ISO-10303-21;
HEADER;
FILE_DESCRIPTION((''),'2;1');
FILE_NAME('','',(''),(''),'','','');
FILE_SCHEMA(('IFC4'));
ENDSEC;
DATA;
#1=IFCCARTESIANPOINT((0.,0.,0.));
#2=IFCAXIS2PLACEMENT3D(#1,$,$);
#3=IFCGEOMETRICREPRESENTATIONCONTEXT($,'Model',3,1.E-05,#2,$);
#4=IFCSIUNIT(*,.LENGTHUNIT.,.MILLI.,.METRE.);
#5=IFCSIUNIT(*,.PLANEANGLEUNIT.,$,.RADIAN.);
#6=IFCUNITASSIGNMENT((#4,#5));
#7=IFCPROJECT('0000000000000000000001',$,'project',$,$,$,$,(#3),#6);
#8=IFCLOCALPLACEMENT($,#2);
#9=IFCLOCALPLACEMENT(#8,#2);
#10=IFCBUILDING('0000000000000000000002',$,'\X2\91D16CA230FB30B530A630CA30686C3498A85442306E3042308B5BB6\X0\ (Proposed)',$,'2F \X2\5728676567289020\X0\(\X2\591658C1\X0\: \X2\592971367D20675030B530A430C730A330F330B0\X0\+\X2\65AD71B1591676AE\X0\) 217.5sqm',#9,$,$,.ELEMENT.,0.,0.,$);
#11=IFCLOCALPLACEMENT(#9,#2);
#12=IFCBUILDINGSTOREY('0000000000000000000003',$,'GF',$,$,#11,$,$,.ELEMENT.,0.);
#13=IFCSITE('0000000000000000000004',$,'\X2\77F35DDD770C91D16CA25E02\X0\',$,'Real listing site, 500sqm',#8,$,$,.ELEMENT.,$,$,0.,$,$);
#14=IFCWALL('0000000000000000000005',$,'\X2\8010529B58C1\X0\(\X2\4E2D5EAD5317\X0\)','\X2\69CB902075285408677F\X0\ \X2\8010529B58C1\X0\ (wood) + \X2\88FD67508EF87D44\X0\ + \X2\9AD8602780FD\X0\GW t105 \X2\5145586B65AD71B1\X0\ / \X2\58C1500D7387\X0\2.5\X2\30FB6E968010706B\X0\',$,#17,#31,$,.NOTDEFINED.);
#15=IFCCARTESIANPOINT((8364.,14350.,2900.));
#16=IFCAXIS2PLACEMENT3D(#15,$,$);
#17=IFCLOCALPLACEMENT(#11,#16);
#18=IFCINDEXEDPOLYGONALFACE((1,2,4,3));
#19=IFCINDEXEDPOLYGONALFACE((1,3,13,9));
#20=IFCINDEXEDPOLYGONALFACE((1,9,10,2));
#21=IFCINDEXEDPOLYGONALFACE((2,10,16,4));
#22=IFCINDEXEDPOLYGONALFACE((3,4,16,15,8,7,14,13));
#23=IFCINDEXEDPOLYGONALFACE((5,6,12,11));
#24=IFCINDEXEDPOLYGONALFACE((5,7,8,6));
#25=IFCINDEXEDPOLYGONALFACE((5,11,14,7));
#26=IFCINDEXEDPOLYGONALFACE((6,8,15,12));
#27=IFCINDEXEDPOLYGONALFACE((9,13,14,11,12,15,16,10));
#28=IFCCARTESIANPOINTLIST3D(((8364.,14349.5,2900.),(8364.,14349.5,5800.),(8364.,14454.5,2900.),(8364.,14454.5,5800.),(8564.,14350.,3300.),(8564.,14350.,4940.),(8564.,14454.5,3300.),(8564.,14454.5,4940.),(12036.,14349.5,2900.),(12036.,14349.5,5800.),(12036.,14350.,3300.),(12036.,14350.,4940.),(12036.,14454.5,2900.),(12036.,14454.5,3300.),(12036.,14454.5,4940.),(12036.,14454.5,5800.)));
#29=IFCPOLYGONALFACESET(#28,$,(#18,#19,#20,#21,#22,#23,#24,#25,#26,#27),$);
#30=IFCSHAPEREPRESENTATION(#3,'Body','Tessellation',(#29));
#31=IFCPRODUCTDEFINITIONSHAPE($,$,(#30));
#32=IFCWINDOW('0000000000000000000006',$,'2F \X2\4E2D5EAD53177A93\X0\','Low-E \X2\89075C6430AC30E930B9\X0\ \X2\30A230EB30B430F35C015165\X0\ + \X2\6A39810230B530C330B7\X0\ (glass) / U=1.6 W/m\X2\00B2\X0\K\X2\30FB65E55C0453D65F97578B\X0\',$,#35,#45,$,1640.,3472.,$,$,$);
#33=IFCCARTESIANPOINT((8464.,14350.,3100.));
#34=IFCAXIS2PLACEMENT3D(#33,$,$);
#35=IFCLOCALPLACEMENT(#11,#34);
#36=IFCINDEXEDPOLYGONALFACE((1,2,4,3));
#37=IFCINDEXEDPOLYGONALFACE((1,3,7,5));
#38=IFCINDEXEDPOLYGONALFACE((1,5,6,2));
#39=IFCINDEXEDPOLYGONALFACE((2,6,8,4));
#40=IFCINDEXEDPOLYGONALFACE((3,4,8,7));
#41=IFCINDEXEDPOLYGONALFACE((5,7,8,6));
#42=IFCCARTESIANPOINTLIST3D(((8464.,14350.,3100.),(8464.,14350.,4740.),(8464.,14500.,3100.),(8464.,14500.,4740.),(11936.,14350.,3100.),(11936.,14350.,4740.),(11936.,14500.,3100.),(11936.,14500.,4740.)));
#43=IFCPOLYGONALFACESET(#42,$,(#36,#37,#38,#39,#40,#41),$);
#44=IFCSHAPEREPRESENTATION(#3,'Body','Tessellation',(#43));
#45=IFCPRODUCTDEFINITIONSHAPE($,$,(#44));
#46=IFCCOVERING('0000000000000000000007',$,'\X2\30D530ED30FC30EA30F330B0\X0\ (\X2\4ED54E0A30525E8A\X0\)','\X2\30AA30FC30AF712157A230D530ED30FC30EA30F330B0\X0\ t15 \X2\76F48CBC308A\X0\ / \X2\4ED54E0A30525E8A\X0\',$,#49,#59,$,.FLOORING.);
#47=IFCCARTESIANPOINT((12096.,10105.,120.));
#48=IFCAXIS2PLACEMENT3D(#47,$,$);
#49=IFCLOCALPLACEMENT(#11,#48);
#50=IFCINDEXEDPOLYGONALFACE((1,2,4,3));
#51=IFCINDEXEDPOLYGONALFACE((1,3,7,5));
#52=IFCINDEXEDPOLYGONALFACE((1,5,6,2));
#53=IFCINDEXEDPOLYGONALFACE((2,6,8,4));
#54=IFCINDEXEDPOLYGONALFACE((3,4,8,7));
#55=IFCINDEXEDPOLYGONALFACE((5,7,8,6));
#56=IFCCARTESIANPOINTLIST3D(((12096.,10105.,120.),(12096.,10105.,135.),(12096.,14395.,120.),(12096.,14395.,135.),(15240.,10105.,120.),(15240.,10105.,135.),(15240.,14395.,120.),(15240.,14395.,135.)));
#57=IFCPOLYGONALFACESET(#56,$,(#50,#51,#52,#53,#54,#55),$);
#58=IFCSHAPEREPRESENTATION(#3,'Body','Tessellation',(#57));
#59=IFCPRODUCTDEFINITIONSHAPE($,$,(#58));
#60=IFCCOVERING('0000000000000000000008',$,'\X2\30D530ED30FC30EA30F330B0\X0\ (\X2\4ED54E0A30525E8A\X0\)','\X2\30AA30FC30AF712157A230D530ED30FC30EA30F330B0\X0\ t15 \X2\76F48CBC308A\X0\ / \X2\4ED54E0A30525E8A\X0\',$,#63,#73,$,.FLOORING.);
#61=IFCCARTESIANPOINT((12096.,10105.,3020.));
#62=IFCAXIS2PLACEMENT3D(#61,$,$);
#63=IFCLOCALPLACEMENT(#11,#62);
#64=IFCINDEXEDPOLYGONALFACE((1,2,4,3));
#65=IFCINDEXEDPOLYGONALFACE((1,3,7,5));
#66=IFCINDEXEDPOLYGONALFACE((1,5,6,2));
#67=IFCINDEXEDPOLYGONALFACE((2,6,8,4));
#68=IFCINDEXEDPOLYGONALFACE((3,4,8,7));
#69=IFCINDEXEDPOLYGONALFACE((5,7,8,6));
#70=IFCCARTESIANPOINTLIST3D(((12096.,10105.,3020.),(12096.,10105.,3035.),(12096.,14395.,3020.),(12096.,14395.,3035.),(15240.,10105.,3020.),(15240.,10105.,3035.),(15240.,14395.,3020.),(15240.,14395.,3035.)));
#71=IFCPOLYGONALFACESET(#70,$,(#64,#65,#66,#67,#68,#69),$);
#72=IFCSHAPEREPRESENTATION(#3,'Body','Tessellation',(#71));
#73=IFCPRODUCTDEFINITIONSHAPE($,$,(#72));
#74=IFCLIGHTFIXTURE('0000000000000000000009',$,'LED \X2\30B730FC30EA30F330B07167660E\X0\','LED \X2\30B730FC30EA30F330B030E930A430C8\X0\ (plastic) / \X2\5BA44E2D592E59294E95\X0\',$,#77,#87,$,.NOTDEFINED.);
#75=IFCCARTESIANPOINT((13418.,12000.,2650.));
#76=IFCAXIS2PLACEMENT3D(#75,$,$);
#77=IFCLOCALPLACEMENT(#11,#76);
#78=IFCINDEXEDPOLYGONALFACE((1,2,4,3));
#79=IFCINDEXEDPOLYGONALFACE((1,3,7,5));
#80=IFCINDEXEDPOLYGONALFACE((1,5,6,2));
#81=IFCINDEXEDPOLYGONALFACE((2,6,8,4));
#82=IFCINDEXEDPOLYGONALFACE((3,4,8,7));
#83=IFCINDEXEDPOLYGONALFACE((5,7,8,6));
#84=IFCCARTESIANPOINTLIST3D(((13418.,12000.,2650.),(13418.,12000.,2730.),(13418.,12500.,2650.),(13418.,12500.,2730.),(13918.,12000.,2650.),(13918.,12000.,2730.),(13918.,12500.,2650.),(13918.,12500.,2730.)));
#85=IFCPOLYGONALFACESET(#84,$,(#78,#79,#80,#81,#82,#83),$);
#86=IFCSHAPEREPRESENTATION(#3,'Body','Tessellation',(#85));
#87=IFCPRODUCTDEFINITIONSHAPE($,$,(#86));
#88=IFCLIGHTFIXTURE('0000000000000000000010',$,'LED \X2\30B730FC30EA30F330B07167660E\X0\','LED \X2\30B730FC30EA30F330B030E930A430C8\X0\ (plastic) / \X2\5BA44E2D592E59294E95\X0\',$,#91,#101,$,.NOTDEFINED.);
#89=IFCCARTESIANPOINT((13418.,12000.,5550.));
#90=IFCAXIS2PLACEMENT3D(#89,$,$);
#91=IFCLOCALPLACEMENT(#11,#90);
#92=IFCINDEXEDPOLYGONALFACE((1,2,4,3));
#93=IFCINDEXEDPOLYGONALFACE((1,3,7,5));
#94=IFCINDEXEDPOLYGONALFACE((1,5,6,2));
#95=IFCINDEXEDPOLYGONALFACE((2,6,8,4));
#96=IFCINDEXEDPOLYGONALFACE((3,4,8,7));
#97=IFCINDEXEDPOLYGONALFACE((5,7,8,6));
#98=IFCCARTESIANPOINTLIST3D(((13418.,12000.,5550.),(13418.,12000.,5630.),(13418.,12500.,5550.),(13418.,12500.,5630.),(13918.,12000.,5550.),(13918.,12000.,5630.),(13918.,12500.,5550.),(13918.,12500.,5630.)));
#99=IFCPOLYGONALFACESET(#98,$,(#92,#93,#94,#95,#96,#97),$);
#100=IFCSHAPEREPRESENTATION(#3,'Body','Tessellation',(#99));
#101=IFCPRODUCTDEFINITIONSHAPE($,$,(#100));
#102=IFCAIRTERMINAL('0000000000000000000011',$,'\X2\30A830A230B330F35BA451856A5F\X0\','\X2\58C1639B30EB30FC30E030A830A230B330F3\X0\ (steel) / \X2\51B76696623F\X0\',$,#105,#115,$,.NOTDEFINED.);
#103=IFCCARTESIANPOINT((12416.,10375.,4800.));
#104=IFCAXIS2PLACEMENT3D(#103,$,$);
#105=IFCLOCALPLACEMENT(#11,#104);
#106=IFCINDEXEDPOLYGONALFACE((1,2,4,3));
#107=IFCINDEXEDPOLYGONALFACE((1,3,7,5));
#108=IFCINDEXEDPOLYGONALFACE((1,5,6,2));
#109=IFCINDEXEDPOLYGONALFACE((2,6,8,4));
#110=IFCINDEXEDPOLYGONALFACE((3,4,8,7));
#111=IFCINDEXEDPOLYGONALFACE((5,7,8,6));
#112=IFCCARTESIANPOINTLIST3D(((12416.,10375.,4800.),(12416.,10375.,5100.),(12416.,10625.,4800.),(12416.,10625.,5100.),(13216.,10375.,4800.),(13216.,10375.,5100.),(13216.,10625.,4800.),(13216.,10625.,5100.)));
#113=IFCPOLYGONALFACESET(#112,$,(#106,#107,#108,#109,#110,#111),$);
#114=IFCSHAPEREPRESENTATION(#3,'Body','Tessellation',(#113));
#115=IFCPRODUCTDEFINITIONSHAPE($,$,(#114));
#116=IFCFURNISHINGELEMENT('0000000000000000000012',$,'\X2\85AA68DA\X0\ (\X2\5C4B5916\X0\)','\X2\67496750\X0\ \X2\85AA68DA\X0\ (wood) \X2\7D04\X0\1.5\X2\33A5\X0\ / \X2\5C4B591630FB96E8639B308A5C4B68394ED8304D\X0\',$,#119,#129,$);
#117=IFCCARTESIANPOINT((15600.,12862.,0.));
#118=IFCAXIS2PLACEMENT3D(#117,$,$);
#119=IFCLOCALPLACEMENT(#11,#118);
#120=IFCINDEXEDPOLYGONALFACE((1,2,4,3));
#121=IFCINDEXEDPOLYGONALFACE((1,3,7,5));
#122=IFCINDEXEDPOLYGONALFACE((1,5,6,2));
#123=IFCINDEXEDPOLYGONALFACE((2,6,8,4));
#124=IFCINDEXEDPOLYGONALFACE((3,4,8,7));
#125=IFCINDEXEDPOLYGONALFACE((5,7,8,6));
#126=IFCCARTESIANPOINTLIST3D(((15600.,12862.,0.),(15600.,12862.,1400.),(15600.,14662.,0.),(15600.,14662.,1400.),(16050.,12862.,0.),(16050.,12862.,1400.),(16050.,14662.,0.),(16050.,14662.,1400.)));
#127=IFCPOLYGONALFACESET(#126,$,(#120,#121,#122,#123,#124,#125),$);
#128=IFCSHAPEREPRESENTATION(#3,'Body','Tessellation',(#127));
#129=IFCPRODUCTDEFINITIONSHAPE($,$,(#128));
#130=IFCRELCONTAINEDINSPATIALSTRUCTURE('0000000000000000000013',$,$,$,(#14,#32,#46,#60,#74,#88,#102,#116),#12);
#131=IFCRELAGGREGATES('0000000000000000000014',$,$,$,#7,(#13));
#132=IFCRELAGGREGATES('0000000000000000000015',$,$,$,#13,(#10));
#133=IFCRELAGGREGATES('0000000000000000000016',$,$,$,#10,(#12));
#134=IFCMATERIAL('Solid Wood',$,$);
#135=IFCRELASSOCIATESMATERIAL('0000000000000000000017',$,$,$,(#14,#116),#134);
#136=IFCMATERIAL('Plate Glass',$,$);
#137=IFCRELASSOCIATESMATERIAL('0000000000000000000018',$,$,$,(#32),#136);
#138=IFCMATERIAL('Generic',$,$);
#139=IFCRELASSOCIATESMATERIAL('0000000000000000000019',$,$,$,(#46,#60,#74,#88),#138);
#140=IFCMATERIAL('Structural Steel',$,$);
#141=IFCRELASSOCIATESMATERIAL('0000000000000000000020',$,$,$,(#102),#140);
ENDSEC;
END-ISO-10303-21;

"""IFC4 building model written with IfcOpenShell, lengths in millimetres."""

from ifc_helpers import new_model, si_unit, frame, frame_2d, origin, place, context, project, spatial, rectangle, extrude, material, element, fill, save


model = new_model("IFC4")

# Units and contexts
model_context = context("Model", 3, precision=1e-05, world=origin())
ifc_project = project(units=[si_unit("LENGTHUNIT", "METRE", prefix="MILLI"), si_unit("PLANEANGLEUNIT", "RADIAN")], contexts=[model_context])

# Site, building, storey
site_placement = place(None, origin())
site = spatial("IfcSite", under=ifc_project, at=site_placement, Name="石川県金沢市", ObjectType="Real listing site, 500sqm", CompositionType="ELEMENT", RefElevation=0.0)
building_placement = place(site_placement, origin())
building = spatial("IfcBuilding", under=site, at=building_placement, Name="金沢・サウナと水風呂のある家 (Proposed)", ObjectType="2F 在来木造(外壁: 天然素材サイディング+断熱外皮) 217.5sqm", CompositionType="ELEMENT", ElevationOfRefHeight=0.0, ElevationOfTerrain=0.0)
storey_placement = place(building_placement, origin())
storey = spatial("IfcBuildingStorey", under=building, at=storey_placement, Name="GF", CompositionType="ELEMENT", Elevation=0.0)

# Shared definitions
ifc_material_1 = material(Name="Solid Wood")

# Wall, opening, window
ifc_material_2 = material(Name="Plate Glass")
wall_1_placement = place(storey_placement, frame((8364.0, 14350.0, 2900.0)))
wall_1 = element("IfcWall", 1, at=wall_1_placement, inside=storey, material=ifc_material_1, Name="耐力壁(中庭北)", Description="構造用合板 耐力壁 (wood) + 製材軸組 + 高性能GW t105 充填断熱 / 壁倍率2.5・準耐火", PredefinedType="NOTDEFINED", context=model_context, shape_type="SweptSolid", body=[
    extrude(rectangle(XDim=3672.0, YDim=105.0, at=frame_2d((1836.0, 52.0))), frame((8364.0, 14350.0, 2900.0)), (0.0, 0.0, 1.0), 2900.0),
])
opening_1_placement = place(storey_placement, frame((8464.0, 14350.0, 3100.0)))
opening_1 = element("IfcOpeningElement", 2, at=opening_1_placement, cuts=wall_1, PredefinedType="NOTDEFINED", context=model_context, shape_type="SweptSolid", body=[
    extrude(rectangle(XDim=3472.0, YDim=150.0, at=frame_2d((1736.0, 75.0))), frame((8464.0, 14350.0, 3100.0)), (0.0, 0.0, 1.0), 1640.0),
])
window_1_placement = place(storey_placement, frame((8464.0, 14350.0, 3100.0)))
window_1 = element("IfcWindow", 3, at=window_1_placement, inside=storey, material=ifc_material_2, Name="2F 中庭北窓", Description="Low-E 複層ガラス アルゴン封入 + 樹脂サッシ (glass) / U=1.6 W/m²K・日射取得型", OverallHeight=1640.0, OverallWidth=3472.0, context=model_context, shape_type="SweptSolid", body=[
    extrude(rectangle(XDim=3472.0, YDim=150.0, at=frame_2d((1736.0, 75.0))), frame((8464.0, 14350.0, 3100.0)), (0.0, 0.0, 1.0), 1640.0),
])
fill(opening_1, window_1)

# Coverings
ifc_material_3 = material(Name="Generic")
covering_1_placement = place(storey_placement, frame((12096.0, 10105.0, 120.0)))
element("IfcCovering", 4, at=covering_1_placement, inside=storey, material=ifc_material_3, Name="フローリング (仕上げ床)", Description="オーク無垢フローリング t15 直貼り / 仕上げ床", PredefinedType="FLOORING", context=model_context, shape_type="SweptSolid", body=[
    extrude(rectangle(XDim=3144.0, YDim=4290.0, at=frame_2d((1572.0, 2145.0))), frame((12096.0, 10105.0, 120.0)), (0.0, 0.0, 1.0), 15.0),
])
covering_2_placement = place(storey_placement, frame((12096.0, 10105.0, 3020.0)))
element("IfcCovering", 5, at=covering_2_placement, inside=storey, material=ifc_material_3, Name="フローリング (仕上げ床)", Description="オーク無垢フローリング t15 直貼り / 仕上げ床", PredefinedType="FLOORING", context=model_context, shape_type="SweptSolid", body=[
    extrude(rectangle(XDim=3144.0, YDim=4290.0, at=frame_2d((1572.0, 2145.0))), frame((12096.0, 10105.0, 3020.0)), (0.0, 0.0, 1.0), 15.0),
])

# Light fixtures
light_fixture_1_placement = place(storey_placement, frame((13418.0, 12000.0, 2650.0)))
element("IfcLightFixture", 6, at=light_fixture_1_placement, inside=storey, material=ifc_material_3, Name="LED シーリング照明", Description="LED シーリングライト (plastic) / 室中央天井", PredefinedType="NOTDEFINED", context=model_context, shape_type="SweptSolid", body=[
    extrude(rectangle(XDim=500.0, YDim=500.0, at=frame_2d((250.0, 250.0))), frame((13418.0, 12000.0, 2650.0)), (0.0, 0.0, 1.0), 80.0),
])
light_fixture_2_placement = place(storey_placement, frame((13418.0, 12000.0, 5550.0)))
element("IfcLightFixture", 7, at=light_fixture_2_placement, inside=storey, material=ifc_material_3, Name="LED シーリング照明", Description="LED シーリングライト (plastic) / 室中央天井", PredefinedType="NOTDEFINED", context=model_context, shape_type="SweptSolid", body=[
    extrude(rectangle(XDim=500.0, YDim=500.0, at=frame_2d((250.0, 250.0))), frame((13418.0, 12000.0, 5550.0)), (0.0, 0.0, 1.0), 80.0),
])

# Air terminal
ifc_material_4 = material(Name="Structural Steel")
air_terminal_placement = place(storey_placement, frame((12416.0, 10375.0, 4800.0)))
element("IfcAirTerminal", 8, at=air_terminal_placement, inside=storey, material=ifc_material_4, Name="エアコン室内機", Description="壁掛ルームエアコン (steel) / 冷暖房", PredefinedType="NOTDEFINED", context=model_context, shape_type="SweptSolid", body=[
    extrude(rectangle(XDim=800.0, YDim=250.0, at=frame_2d((400.0, 125.0))), frame((12416.0, 10375.0, 4800.0)), (0.0, 0.0, 1.0), 300.0),
])

# Furnishing element
furnishing_placement = place(storey_placement, frame((15600.0, 12862.0, 0.0)))
element("IfcFurnishingElement", 9, at=furnishing_placement, inside=storey, material=ifc_material_1, Name="薪棚 (屋外)", Description="杉材 薪棚 (wood) 約1.5㎥ / 屋外・雨掛り屋根付き", context=model_context, shape_type="SweptSolid", body=[
    extrude(rectangle(XDim=450.0, YDim=1800.0, at=frame_2d((225.0, 900.0))), frame((15600.0, 12862.0, 0.0)), (0.0, 0.0, 1.0), 1400.0),
])

save(model, "model.ifc")
